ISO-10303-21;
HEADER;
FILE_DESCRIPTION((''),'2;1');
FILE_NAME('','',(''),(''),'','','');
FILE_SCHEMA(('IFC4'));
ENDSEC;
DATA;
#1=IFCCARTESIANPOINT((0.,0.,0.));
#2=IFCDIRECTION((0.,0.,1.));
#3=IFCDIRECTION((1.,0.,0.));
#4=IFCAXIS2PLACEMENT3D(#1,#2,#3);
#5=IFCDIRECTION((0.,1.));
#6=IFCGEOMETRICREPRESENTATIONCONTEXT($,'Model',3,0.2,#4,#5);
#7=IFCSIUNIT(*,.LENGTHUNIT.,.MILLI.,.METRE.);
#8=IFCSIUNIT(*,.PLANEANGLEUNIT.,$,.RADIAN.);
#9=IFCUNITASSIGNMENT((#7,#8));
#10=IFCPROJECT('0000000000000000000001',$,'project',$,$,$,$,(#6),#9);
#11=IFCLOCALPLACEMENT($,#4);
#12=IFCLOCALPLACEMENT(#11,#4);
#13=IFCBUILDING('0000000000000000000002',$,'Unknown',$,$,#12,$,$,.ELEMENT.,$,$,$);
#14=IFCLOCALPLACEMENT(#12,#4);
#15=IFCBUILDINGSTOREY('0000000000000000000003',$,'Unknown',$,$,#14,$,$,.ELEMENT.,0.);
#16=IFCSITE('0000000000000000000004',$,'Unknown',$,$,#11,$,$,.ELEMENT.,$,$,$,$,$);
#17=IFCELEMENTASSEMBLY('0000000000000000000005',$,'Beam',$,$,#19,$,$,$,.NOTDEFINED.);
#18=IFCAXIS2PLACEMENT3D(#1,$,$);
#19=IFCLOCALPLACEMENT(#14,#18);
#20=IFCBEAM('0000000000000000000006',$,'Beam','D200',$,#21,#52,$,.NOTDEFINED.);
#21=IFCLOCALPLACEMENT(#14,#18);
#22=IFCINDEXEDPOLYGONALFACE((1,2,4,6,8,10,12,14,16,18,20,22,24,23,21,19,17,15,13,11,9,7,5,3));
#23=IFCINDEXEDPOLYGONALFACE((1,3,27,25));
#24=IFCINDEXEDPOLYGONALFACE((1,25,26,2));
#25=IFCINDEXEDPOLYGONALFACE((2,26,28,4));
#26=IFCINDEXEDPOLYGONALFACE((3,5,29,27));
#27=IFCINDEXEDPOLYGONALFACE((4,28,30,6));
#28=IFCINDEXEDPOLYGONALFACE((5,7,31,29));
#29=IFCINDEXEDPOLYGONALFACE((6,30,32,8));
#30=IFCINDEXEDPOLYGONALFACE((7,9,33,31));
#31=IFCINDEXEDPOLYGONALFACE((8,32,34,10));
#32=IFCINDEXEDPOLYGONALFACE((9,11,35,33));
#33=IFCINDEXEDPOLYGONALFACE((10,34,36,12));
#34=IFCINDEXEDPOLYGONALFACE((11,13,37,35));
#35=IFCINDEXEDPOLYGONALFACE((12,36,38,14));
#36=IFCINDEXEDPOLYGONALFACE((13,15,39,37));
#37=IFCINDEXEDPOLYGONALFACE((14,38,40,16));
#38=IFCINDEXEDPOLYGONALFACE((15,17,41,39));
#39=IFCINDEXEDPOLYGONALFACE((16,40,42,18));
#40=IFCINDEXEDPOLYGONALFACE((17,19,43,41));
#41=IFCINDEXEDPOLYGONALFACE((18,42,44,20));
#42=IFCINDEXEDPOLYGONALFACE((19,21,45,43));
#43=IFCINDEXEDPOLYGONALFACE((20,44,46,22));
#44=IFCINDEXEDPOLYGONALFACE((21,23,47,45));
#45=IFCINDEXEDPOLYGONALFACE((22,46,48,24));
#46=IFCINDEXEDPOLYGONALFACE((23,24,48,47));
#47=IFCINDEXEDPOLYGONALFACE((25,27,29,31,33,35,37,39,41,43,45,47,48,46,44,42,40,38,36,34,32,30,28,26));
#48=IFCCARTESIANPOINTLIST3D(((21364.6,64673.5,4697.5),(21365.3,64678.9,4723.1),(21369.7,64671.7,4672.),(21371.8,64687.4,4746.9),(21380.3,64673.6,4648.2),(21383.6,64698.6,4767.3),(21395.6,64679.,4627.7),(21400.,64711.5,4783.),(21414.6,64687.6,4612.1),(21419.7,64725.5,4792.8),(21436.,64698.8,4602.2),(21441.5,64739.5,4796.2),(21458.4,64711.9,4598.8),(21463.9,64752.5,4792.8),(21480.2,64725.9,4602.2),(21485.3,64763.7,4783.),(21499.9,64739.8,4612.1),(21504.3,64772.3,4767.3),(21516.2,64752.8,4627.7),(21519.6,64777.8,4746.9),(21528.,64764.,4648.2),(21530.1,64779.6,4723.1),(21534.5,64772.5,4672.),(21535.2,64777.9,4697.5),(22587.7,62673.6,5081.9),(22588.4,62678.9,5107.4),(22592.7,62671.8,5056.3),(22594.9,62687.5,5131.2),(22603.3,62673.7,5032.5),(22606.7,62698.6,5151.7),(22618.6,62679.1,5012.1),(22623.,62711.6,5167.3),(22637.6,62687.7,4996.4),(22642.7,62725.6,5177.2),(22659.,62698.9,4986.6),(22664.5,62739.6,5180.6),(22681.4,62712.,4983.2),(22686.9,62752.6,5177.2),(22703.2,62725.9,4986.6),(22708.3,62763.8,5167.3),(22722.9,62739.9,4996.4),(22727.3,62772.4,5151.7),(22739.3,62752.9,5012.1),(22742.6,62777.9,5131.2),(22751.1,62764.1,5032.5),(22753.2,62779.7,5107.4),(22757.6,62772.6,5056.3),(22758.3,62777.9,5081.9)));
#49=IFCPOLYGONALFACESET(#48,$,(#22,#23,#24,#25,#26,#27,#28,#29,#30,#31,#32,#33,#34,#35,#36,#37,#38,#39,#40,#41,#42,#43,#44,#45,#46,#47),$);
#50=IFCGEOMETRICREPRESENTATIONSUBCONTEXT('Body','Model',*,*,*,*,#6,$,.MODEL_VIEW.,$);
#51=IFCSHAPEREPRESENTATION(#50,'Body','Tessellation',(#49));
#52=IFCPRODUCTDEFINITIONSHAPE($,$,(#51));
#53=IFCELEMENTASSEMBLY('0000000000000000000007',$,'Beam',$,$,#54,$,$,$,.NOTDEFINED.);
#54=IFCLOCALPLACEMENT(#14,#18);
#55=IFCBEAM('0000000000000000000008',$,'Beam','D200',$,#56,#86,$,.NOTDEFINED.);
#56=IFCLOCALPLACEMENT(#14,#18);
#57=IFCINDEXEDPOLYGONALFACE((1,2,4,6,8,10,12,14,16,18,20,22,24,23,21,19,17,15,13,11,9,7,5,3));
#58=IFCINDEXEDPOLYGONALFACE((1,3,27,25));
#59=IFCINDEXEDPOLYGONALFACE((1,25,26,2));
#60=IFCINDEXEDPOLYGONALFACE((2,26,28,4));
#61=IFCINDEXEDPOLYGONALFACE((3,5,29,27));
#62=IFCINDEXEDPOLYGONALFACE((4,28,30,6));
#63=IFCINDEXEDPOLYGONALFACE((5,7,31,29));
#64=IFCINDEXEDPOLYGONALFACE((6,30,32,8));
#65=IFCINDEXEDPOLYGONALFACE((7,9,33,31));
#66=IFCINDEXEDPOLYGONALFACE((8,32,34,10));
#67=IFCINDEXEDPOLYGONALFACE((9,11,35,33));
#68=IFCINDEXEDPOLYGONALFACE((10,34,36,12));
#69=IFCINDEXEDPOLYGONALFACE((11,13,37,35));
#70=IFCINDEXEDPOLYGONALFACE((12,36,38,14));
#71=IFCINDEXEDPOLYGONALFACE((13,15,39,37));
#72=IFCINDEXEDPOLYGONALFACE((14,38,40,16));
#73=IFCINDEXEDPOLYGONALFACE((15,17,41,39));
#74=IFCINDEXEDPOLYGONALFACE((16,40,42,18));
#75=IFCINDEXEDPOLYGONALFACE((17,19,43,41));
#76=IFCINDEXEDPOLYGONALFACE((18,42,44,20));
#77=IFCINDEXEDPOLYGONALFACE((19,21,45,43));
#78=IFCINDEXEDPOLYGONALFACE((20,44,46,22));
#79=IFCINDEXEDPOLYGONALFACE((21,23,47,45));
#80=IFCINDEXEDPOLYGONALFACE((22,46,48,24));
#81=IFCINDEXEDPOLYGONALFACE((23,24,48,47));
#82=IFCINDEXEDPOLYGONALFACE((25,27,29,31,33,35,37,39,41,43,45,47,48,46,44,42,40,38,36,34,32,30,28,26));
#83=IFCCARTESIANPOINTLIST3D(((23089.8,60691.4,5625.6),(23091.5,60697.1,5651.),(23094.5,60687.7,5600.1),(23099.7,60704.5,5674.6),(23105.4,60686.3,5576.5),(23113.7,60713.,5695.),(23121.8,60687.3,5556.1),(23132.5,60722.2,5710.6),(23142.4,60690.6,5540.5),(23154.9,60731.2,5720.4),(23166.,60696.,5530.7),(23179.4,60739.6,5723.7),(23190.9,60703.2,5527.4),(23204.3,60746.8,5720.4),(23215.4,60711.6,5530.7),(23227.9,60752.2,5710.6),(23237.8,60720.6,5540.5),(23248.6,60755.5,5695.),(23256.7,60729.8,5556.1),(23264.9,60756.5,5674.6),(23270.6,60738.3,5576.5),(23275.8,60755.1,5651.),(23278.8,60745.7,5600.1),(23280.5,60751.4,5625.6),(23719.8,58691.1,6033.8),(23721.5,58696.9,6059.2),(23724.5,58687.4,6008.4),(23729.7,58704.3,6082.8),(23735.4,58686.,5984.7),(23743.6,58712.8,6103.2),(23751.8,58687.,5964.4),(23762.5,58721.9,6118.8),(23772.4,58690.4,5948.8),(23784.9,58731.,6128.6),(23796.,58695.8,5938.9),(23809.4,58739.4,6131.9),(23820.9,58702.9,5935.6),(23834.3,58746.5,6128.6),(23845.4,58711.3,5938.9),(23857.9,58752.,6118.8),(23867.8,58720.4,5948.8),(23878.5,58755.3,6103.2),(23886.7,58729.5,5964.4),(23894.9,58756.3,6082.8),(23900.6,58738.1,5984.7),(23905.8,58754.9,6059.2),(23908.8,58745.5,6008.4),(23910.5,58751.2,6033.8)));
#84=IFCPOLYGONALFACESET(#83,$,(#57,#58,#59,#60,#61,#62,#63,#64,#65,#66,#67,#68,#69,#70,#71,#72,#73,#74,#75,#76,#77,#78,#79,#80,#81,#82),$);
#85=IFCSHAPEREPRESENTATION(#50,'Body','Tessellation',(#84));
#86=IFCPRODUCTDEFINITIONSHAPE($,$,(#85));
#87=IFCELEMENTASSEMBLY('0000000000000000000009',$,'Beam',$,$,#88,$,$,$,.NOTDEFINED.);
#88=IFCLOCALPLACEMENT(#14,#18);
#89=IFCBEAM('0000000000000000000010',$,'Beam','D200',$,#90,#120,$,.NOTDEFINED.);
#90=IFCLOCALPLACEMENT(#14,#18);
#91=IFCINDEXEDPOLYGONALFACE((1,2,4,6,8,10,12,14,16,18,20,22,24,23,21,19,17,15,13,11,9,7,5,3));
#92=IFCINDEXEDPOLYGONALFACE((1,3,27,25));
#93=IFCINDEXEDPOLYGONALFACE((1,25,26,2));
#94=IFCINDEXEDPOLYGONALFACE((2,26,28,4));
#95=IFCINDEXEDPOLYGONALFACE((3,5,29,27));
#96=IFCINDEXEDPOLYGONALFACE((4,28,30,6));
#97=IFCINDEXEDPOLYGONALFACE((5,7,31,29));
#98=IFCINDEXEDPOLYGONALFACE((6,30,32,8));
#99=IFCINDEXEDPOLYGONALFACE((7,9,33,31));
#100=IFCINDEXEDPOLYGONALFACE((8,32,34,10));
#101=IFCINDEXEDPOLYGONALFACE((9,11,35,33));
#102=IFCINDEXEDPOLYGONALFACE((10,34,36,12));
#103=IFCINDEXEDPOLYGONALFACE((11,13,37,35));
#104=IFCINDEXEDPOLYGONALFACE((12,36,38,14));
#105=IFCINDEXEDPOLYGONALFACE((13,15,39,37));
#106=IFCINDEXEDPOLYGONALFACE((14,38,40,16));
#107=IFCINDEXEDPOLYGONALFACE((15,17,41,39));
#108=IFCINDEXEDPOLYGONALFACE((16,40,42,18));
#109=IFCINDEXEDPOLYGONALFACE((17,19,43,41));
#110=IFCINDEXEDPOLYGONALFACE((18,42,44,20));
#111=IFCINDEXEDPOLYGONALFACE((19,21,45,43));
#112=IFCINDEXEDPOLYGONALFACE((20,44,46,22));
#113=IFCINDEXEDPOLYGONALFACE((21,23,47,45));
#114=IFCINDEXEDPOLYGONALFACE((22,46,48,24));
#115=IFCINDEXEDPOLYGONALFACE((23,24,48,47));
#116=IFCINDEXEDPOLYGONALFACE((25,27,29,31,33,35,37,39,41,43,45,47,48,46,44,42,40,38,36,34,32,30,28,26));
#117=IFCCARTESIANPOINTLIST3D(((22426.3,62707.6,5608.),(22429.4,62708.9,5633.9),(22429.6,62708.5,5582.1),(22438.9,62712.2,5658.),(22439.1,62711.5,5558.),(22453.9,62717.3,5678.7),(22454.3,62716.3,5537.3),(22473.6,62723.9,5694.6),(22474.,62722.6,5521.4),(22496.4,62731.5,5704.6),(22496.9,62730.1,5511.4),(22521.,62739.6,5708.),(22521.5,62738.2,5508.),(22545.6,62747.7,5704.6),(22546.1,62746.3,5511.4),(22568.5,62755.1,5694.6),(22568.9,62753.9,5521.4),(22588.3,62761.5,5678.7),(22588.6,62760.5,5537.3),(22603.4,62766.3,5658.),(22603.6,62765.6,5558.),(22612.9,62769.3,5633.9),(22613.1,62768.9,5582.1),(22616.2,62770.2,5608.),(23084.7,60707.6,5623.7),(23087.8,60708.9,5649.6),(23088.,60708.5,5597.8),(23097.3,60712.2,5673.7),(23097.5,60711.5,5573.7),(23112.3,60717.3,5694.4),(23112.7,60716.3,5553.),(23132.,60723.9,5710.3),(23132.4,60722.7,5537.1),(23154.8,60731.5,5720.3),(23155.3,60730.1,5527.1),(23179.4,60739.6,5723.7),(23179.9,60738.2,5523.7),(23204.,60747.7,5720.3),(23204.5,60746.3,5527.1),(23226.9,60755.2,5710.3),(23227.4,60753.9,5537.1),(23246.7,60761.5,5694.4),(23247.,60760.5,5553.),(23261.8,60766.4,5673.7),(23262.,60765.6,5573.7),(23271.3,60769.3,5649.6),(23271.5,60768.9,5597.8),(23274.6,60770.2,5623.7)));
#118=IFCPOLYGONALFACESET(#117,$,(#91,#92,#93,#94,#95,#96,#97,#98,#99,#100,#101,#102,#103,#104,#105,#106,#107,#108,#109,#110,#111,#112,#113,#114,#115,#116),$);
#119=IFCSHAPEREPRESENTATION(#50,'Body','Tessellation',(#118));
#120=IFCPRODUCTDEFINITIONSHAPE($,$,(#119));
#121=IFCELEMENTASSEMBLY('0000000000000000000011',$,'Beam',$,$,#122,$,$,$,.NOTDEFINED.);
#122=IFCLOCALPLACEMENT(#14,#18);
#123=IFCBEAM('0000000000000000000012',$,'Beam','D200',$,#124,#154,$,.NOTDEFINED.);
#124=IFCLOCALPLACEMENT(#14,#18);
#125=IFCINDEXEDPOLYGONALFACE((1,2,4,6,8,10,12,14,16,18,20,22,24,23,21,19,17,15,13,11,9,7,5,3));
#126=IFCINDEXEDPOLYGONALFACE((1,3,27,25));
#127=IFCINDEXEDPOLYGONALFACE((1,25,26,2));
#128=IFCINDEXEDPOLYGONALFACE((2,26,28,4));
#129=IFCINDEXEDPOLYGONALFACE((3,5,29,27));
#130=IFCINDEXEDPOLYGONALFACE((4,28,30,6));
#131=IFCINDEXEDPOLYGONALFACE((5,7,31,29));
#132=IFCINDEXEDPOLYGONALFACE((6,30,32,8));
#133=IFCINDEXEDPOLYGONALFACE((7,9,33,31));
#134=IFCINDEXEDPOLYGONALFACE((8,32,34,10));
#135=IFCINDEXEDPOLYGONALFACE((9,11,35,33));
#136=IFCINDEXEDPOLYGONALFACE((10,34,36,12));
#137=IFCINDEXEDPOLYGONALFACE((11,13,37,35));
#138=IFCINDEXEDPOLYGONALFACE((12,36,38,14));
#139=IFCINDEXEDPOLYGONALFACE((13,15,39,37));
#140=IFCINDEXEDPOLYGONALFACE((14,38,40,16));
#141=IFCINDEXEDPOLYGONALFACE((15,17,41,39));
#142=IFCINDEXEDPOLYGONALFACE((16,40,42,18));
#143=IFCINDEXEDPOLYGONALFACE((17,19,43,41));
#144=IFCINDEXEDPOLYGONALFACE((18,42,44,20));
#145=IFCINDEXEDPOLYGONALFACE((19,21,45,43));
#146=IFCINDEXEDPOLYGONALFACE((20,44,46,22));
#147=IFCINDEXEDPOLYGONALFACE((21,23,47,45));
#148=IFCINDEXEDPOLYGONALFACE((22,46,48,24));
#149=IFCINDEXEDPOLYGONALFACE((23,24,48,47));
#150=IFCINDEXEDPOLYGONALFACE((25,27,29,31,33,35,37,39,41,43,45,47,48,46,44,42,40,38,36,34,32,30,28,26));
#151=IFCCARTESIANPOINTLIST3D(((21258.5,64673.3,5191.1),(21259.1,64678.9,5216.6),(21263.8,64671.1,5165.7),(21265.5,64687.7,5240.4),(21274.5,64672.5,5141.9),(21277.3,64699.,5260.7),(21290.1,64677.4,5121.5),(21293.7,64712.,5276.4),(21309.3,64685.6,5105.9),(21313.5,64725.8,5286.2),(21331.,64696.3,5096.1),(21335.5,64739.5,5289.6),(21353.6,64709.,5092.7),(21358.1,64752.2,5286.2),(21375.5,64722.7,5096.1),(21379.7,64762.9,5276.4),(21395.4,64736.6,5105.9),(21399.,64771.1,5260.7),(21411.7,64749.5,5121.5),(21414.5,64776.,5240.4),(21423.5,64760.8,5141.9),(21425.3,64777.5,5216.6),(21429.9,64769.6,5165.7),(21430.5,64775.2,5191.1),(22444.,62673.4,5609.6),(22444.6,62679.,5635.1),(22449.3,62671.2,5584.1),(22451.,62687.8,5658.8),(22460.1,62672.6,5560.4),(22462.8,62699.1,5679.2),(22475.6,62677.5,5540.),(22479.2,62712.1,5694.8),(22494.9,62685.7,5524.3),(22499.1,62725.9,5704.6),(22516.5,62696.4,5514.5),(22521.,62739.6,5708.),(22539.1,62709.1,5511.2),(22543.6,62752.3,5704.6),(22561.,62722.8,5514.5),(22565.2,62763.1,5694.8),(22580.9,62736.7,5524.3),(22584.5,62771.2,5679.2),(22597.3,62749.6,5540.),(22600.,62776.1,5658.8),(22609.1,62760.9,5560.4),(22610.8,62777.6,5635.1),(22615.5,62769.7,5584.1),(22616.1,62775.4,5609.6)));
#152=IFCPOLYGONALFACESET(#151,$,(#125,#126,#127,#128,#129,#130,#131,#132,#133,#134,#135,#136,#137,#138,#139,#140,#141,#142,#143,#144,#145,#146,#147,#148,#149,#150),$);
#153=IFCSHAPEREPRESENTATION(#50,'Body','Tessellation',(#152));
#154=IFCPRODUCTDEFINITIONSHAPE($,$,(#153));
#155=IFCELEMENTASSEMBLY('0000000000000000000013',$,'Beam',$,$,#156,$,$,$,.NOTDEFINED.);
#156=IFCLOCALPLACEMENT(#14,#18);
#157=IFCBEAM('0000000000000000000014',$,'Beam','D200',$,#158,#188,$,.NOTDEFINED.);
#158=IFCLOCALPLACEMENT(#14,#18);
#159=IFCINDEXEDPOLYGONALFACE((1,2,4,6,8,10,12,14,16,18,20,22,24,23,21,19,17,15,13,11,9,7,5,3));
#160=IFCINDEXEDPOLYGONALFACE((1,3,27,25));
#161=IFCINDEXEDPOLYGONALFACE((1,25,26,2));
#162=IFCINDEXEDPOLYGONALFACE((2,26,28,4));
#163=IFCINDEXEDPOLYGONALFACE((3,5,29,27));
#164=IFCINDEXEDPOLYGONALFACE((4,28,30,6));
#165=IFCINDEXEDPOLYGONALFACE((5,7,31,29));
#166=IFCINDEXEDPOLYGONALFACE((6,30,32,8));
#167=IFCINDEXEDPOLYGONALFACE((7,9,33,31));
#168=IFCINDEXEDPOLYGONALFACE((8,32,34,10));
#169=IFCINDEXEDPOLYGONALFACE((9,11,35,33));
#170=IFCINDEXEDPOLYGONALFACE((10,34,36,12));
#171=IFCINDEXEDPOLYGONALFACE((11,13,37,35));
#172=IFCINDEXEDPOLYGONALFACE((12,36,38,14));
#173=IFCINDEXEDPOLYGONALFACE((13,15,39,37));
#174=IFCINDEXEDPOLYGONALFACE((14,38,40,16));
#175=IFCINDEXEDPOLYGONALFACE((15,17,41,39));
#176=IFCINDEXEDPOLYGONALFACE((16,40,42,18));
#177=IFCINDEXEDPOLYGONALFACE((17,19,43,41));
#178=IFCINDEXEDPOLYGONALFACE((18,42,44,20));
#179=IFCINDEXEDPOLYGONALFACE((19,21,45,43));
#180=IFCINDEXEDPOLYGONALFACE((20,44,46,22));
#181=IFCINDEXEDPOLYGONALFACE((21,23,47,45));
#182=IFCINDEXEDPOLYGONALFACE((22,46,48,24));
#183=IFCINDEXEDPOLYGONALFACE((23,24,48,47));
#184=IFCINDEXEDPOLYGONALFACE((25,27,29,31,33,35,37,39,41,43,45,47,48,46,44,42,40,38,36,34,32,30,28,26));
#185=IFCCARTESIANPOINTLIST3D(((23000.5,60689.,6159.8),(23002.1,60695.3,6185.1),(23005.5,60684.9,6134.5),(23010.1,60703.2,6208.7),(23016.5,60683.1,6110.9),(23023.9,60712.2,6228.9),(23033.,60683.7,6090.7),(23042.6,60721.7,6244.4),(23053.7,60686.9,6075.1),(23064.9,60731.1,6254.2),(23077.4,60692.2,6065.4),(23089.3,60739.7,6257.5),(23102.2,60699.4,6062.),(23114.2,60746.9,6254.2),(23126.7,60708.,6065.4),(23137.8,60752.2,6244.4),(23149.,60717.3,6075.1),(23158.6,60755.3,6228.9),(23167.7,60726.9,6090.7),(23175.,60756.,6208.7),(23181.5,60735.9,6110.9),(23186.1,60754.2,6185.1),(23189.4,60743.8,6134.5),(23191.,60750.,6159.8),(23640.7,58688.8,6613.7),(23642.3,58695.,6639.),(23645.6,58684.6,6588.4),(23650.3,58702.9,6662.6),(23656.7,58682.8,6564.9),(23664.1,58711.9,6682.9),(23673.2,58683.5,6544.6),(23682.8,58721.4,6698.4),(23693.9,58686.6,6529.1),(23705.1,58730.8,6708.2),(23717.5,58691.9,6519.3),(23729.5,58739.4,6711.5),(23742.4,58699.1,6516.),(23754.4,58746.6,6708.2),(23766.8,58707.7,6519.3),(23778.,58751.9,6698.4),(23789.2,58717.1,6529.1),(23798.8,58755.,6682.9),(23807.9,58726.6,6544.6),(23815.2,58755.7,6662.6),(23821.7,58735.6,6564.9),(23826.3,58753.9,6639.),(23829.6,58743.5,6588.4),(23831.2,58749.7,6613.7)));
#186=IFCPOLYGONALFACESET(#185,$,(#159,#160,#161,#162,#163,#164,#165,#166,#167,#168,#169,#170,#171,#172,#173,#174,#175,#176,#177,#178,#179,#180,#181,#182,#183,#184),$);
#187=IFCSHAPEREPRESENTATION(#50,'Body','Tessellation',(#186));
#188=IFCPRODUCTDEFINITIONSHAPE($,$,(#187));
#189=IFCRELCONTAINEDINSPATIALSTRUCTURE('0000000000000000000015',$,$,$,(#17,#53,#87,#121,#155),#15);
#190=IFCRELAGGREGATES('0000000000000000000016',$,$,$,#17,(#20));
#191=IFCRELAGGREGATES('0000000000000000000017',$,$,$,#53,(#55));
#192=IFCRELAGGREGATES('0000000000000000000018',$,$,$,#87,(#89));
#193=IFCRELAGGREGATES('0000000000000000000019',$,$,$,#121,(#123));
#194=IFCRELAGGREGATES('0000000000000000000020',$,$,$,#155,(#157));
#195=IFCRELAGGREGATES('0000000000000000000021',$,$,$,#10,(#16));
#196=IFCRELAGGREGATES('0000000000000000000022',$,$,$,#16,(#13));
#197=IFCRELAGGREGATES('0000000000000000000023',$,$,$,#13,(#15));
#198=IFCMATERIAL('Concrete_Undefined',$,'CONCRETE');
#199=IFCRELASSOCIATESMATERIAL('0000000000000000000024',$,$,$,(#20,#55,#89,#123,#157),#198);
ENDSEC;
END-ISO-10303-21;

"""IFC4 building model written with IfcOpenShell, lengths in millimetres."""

from ifc_helpers import new_model, si_unit, direction, frame, origin_with_axes, place, context, subcontext, project, spatial, line, indexed_curve, outline, extrude, material, element, aggregate, save


model = new_model("IFC4")

# Units and contexts
model_context = context("Model", 3, precision=0.2, world=origin_with_axes(), true_north=direction((0.0, 1.0)))
body_context = subcontext(model_context, "Body", "Model", "MODEL_VIEW")
ifc_project = project(units=[si_unit("LENGTHUNIT", "METRE", prefix="MILLI"), si_unit("PLANEANGLEUNIT", "RADIAN")], contexts=[model_context])

# Site, building, storey
site_placement = place(None, origin_with_axes())
site = spatial("IfcSite", under=ifc_project, at=site_placement, Name="Unknown", CompositionType="ELEMENT")
building_placement = place(site_placement, origin_with_axes())
building = spatial("IfcBuilding", under=site, at=building_placement, Name="Unknown", CompositionType="ELEMENT")
storey_placement = place(building_placement, origin_with_axes())
storey = spatial("IfcBuildingStorey", under=building, at=storey_placement, Name="Unknown", CompositionType="ELEMENT", Elevation=0.0)

# Element assemblies, beams
ifc_material = material(Name="Concrete_Undefined", Category="CONCRETE")
assembly_1_placement = place(storey_placement, frame((21449.9, 64725.7, 4697.5), z_axis=(-0.853118, -0.521719, 0.0), x_axis=(0.514845, -0.841877, 0.161795)))
assembly_1 = element("IfcElementAssembly", 1, at=assembly_1_placement, inside=storey, Name="Beam", PredefinedType="NOTDEFINED")
beam_1_placement = place(assembly_1_placement, origin_with_axes())
beam_1 = element("IfcBeam", 2, at=beam_1_placement, material=ifc_material, Name="Beam", Description="D200", PredefinedType="NOTDEFINED", context=body_context, shape_type="SolidModel", body=[
    extrude(outline(indexed_curve([(100.0, 0.0), (96.6, 25.9), (86.6, 50.0), (70.7, 70.7), (50.0, 86.6), (25.9, 96.6), (0.0, 100.0), (-25.9, 96.6), (-50.0, 86.6), (-70.7, 70.7), (-86.6, 50.0), (-96.6, 25.9), (-100.0, 0.0), (-96.6, -25.9), (-86.6, -50.0), (-70.7, -70.7), (-50.0, -86.6), (-25.9, -96.6), (0.0, -100.0), (25.9, -96.6), (50.0, -86.6), (70.7, -70.7), (86.6, -50.0), (96.6, -25.9)], segments=[line(1, 2, 3, 4, 5, 6, 7, 8, 9, 10, 11, 12, 13, 14, 15, 16, 17, 18, 19, 20, 21, 22, 23, 24, 1)])), frame((0.0, 0.0, 0.0), z_axis=(-1.0, 0.0, 0.0), x_axis=(0.0, 0.0, 1.0)), (0.0, 0.0, -1.0), 2375.5),
])
aggregate(assembly_1, [beam_1])
assembly_2_placement = place(storey_placement, frame((23185.2, 60721.4, 5625.6), z_axis=(-0.953811, -0.300408, 0.0), x_axis=(0.294873, -0.936239, 0.191068)))
assembly_2 = element("IfcElementAssembly", 3, at=assembly_2_placement, inside=storey, Name="Beam", PredefinedType="NOTDEFINED")
beam_2_placement = place(assembly_2_placement, origin_with_axes())
beam_2 = element("IfcBeam", 4, at=beam_2_placement, material=ifc_material, Name="Beam", Description="D200", PredefinedType="NOTDEFINED", context=body_context, shape_type="SolidModel", body=[
    extrude(outline(indexed_curve([(100.0, 0.0), (96.6, 25.9), (86.6, 50.0), (70.7, 70.7), (50.0, 86.6), (25.9, 96.6), (0.0, 100.0), (-25.9, 96.6), (-50.0, 86.6), (-70.7, 70.7), (-86.6, 50.0), (-96.6, 25.9), (-100.0, 0.0), (-96.6, -25.9), (-86.6, -50.0), (-70.7, -70.7), (-50.0, -86.6), (-25.9, -96.6), (0.0, -100.0), (25.9, -96.6), (50.0, -86.6), (70.7, -70.7), (86.6, -50.0), (96.6, -25.9)], segments=[line(1, 2, 3, 4, 5, 6, 7, 8, 9, 10, 11, 12, 13, 14, 15, 16, 17, 18, 19, 20, 21, 22, 23, 24, 1)])), frame((0.0, 0.0, 0.0), z_axis=(-1.0, 0.0, 0.0), x_axis=(0.0, 0.0, 1.0)), (0.0, 0.0, -1.0), 2136.5),
])
aggregate(assembly_2, [beam_2])
assembly_3_placement = place(storey_placement, frame((22521.3, 62738.9, 5608.0), z_axis=(-0.949853, -0.312698, 0.0), x_axis=(0.312689, -0.949826, 0.007461)))
assembly_3 = element("IfcElementAssembly", 5, at=assembly_3_placement, inside=storey, Name="Beam", PredefinedType="NOTDEFINED")
beam_3_placement = place(assembly_3_placement, origin_with_axes())
beam_3 = element("IfcBeam", 6, at=beam_3_placement, material=ifc_material, Name="Beam", Description="D200", PredefinedType="NOTDEFINED", context=body_context, shape_type="SolidModel", body=[
    extrude(outline(indexed_curve([(100.0, 0.0), (96.6, 25.9), (86.6, 50.0), (70.7, 70.7), (50.0, 86.6), (25.9, 96.6), (0.0, 100.0), (-25.9, 96.6), (-50.0, 86.6), (-70.7, 70.7), (-86.6, 50.0), (-96.6, 25.9), (-100.0, 0.0), (-96.6, -25.9), (-86.6, -50.0), (-70.7, -70.7), (-50.0, -86.6), (-25.9, -96.6), (0.0, -100.0), (25.9, -96.6), (50.0, -86.6), (70.7, -70.7), (86.6, -50.0), (96.6, -25.9)], segments=[line(1, 2, 3, 4, 5, 6, 7, 8, 9, 10, 11, 12, 13, 14, 15, 16, 17, 18, 19, 20, 21, 22, 23, 24, 1)])), frame((0.0, 0.0, 0.0), z_axis=(-1.0, 0.0, 0.0), x_axis=(0.0, 0.0, 1.0)), (0.0, 0.0, -1.0), 2105.6),
])
aggregate(assembly_3, [beam_3])
assembly_4_placement = place(storey_placement, frame((21344.5, 64724.3, 5191.1), z_axis=(-0.860214, -0.509933, 0.0), x_axis=(0.501869, -0.846611, 0.177137)))
assembly_4 = element("IfcElementAssembly", 7, at=assembly_4_placement, inside=storey, Name="Beam", PredefinedType="NOTDEFINED")
beam_4_placement = place(assembly_4_placement, origin_with_axes())
beam_4 = element("IfcBeam", 8, at=beam_4_placement, material=ifc_material, Name="Beam", Description="D200", PredefinedType="NOTDEFINED", context=body_context, shape_type="SolidModel", body=[
    extrude(outline(indexed_curve([(100.0, 0.0), (96.6, 25.9), (86.6, 50.0), (70.7, 70.7), (50.0, 86.6), (25.9, 96.6), (0.0, 100.0), (-25.9, 96.6), (-50.0, 86.6), (-70.7, 70.7), (-86.6, 50.0), (-96.6, 25.9), (-100.0, 0.0), (-96.6, -25.9), (-86.6, -50.0), (-70.7, -70.7), (-50.0, -86.6), (-25.9, -96.6), (0.0, -100.0), (25.9, -96.6), (50.0, -86.6), (70.7, -70.7), (86.6, -50.0), (96.6, -25.9)], segments=[line(1, 2, 3, 4, 5, 6, 7, 8, 9, 10, 11, 12, 13, 14, 15, 16, 17, 18, 19, 20, 21, 22, 23, 24, 1)])), frame((0.0, 0.0, 0.0), z_axis=(-1.0, 0.0, 0.0), x_axis=(0.0, 0.0, 1.0)), (0.0, 0.0, -1.0), 2362.2),
])
aggregate(assembly_4, [beam_4])
assembly_5_placement = place(storey_placement, frame((23095.8, 60719.5, 6159.8), z_axis=(-0.952411, -0.304816, 0.0), x_axis=(0.297935, -0.930913, 0.211271)))
assembly_5 = element("IfcElementAssembly", 9, at=assembly_5_placement, inside=storey, Name="Beam", PredefinedType="NOTDEFINED")
beam_5_placement = place(assembly_5_placement, origin_with_axes())
beam_5 = element("IfcBeam", 10, at=beam_5_placement, material=ifc_material, Name="Beam", Description="D200", PredefinedType="NOTDEFINED", context=body_context, shape_type="SolidModel", body=[
    extrude(outline(indexed_curve([(100.0, 0.0), (96.6, 25.9), (86.6, 50.0), (70.7, 70.7), (50.0, 86.6), (25.9, 96.6), (0.0, 100.0), (-25.9, 96.6), (-50.0, 86.6), (-70.7, 70.7), (-86.6, 50.0), (-96.6, 25.9), (-100.0, 0.0), (-96.6, -25.9), (-86.6, -50.0), (-70.7, -70.7), (-50.0, -86.6), (-25.9, -96.6), (0.0, -100.0), (25.9, -96.6), (50.0, -86.6), (70.7, -70.7), (86.6, -50.0), (96.6, -25.9)], segments=[line(1, 2, 3, 4, 5, 6, 7, 8, 9, 10, 11, 12, 13, 14, 15, 16, 17, 18, 19, 20, 21, 22, 23, 24, 1)])), frame((0.0, 0.0, 0.0), z_axis=(-1.0, 0.0, 0.0), x_axis=(0.0, 0.0, 1.0)), (0.0, 0.0, -1.0), 2148.7),
])
aggregate(assembly_5, [beam_5])

save(model, "model.ifc")
